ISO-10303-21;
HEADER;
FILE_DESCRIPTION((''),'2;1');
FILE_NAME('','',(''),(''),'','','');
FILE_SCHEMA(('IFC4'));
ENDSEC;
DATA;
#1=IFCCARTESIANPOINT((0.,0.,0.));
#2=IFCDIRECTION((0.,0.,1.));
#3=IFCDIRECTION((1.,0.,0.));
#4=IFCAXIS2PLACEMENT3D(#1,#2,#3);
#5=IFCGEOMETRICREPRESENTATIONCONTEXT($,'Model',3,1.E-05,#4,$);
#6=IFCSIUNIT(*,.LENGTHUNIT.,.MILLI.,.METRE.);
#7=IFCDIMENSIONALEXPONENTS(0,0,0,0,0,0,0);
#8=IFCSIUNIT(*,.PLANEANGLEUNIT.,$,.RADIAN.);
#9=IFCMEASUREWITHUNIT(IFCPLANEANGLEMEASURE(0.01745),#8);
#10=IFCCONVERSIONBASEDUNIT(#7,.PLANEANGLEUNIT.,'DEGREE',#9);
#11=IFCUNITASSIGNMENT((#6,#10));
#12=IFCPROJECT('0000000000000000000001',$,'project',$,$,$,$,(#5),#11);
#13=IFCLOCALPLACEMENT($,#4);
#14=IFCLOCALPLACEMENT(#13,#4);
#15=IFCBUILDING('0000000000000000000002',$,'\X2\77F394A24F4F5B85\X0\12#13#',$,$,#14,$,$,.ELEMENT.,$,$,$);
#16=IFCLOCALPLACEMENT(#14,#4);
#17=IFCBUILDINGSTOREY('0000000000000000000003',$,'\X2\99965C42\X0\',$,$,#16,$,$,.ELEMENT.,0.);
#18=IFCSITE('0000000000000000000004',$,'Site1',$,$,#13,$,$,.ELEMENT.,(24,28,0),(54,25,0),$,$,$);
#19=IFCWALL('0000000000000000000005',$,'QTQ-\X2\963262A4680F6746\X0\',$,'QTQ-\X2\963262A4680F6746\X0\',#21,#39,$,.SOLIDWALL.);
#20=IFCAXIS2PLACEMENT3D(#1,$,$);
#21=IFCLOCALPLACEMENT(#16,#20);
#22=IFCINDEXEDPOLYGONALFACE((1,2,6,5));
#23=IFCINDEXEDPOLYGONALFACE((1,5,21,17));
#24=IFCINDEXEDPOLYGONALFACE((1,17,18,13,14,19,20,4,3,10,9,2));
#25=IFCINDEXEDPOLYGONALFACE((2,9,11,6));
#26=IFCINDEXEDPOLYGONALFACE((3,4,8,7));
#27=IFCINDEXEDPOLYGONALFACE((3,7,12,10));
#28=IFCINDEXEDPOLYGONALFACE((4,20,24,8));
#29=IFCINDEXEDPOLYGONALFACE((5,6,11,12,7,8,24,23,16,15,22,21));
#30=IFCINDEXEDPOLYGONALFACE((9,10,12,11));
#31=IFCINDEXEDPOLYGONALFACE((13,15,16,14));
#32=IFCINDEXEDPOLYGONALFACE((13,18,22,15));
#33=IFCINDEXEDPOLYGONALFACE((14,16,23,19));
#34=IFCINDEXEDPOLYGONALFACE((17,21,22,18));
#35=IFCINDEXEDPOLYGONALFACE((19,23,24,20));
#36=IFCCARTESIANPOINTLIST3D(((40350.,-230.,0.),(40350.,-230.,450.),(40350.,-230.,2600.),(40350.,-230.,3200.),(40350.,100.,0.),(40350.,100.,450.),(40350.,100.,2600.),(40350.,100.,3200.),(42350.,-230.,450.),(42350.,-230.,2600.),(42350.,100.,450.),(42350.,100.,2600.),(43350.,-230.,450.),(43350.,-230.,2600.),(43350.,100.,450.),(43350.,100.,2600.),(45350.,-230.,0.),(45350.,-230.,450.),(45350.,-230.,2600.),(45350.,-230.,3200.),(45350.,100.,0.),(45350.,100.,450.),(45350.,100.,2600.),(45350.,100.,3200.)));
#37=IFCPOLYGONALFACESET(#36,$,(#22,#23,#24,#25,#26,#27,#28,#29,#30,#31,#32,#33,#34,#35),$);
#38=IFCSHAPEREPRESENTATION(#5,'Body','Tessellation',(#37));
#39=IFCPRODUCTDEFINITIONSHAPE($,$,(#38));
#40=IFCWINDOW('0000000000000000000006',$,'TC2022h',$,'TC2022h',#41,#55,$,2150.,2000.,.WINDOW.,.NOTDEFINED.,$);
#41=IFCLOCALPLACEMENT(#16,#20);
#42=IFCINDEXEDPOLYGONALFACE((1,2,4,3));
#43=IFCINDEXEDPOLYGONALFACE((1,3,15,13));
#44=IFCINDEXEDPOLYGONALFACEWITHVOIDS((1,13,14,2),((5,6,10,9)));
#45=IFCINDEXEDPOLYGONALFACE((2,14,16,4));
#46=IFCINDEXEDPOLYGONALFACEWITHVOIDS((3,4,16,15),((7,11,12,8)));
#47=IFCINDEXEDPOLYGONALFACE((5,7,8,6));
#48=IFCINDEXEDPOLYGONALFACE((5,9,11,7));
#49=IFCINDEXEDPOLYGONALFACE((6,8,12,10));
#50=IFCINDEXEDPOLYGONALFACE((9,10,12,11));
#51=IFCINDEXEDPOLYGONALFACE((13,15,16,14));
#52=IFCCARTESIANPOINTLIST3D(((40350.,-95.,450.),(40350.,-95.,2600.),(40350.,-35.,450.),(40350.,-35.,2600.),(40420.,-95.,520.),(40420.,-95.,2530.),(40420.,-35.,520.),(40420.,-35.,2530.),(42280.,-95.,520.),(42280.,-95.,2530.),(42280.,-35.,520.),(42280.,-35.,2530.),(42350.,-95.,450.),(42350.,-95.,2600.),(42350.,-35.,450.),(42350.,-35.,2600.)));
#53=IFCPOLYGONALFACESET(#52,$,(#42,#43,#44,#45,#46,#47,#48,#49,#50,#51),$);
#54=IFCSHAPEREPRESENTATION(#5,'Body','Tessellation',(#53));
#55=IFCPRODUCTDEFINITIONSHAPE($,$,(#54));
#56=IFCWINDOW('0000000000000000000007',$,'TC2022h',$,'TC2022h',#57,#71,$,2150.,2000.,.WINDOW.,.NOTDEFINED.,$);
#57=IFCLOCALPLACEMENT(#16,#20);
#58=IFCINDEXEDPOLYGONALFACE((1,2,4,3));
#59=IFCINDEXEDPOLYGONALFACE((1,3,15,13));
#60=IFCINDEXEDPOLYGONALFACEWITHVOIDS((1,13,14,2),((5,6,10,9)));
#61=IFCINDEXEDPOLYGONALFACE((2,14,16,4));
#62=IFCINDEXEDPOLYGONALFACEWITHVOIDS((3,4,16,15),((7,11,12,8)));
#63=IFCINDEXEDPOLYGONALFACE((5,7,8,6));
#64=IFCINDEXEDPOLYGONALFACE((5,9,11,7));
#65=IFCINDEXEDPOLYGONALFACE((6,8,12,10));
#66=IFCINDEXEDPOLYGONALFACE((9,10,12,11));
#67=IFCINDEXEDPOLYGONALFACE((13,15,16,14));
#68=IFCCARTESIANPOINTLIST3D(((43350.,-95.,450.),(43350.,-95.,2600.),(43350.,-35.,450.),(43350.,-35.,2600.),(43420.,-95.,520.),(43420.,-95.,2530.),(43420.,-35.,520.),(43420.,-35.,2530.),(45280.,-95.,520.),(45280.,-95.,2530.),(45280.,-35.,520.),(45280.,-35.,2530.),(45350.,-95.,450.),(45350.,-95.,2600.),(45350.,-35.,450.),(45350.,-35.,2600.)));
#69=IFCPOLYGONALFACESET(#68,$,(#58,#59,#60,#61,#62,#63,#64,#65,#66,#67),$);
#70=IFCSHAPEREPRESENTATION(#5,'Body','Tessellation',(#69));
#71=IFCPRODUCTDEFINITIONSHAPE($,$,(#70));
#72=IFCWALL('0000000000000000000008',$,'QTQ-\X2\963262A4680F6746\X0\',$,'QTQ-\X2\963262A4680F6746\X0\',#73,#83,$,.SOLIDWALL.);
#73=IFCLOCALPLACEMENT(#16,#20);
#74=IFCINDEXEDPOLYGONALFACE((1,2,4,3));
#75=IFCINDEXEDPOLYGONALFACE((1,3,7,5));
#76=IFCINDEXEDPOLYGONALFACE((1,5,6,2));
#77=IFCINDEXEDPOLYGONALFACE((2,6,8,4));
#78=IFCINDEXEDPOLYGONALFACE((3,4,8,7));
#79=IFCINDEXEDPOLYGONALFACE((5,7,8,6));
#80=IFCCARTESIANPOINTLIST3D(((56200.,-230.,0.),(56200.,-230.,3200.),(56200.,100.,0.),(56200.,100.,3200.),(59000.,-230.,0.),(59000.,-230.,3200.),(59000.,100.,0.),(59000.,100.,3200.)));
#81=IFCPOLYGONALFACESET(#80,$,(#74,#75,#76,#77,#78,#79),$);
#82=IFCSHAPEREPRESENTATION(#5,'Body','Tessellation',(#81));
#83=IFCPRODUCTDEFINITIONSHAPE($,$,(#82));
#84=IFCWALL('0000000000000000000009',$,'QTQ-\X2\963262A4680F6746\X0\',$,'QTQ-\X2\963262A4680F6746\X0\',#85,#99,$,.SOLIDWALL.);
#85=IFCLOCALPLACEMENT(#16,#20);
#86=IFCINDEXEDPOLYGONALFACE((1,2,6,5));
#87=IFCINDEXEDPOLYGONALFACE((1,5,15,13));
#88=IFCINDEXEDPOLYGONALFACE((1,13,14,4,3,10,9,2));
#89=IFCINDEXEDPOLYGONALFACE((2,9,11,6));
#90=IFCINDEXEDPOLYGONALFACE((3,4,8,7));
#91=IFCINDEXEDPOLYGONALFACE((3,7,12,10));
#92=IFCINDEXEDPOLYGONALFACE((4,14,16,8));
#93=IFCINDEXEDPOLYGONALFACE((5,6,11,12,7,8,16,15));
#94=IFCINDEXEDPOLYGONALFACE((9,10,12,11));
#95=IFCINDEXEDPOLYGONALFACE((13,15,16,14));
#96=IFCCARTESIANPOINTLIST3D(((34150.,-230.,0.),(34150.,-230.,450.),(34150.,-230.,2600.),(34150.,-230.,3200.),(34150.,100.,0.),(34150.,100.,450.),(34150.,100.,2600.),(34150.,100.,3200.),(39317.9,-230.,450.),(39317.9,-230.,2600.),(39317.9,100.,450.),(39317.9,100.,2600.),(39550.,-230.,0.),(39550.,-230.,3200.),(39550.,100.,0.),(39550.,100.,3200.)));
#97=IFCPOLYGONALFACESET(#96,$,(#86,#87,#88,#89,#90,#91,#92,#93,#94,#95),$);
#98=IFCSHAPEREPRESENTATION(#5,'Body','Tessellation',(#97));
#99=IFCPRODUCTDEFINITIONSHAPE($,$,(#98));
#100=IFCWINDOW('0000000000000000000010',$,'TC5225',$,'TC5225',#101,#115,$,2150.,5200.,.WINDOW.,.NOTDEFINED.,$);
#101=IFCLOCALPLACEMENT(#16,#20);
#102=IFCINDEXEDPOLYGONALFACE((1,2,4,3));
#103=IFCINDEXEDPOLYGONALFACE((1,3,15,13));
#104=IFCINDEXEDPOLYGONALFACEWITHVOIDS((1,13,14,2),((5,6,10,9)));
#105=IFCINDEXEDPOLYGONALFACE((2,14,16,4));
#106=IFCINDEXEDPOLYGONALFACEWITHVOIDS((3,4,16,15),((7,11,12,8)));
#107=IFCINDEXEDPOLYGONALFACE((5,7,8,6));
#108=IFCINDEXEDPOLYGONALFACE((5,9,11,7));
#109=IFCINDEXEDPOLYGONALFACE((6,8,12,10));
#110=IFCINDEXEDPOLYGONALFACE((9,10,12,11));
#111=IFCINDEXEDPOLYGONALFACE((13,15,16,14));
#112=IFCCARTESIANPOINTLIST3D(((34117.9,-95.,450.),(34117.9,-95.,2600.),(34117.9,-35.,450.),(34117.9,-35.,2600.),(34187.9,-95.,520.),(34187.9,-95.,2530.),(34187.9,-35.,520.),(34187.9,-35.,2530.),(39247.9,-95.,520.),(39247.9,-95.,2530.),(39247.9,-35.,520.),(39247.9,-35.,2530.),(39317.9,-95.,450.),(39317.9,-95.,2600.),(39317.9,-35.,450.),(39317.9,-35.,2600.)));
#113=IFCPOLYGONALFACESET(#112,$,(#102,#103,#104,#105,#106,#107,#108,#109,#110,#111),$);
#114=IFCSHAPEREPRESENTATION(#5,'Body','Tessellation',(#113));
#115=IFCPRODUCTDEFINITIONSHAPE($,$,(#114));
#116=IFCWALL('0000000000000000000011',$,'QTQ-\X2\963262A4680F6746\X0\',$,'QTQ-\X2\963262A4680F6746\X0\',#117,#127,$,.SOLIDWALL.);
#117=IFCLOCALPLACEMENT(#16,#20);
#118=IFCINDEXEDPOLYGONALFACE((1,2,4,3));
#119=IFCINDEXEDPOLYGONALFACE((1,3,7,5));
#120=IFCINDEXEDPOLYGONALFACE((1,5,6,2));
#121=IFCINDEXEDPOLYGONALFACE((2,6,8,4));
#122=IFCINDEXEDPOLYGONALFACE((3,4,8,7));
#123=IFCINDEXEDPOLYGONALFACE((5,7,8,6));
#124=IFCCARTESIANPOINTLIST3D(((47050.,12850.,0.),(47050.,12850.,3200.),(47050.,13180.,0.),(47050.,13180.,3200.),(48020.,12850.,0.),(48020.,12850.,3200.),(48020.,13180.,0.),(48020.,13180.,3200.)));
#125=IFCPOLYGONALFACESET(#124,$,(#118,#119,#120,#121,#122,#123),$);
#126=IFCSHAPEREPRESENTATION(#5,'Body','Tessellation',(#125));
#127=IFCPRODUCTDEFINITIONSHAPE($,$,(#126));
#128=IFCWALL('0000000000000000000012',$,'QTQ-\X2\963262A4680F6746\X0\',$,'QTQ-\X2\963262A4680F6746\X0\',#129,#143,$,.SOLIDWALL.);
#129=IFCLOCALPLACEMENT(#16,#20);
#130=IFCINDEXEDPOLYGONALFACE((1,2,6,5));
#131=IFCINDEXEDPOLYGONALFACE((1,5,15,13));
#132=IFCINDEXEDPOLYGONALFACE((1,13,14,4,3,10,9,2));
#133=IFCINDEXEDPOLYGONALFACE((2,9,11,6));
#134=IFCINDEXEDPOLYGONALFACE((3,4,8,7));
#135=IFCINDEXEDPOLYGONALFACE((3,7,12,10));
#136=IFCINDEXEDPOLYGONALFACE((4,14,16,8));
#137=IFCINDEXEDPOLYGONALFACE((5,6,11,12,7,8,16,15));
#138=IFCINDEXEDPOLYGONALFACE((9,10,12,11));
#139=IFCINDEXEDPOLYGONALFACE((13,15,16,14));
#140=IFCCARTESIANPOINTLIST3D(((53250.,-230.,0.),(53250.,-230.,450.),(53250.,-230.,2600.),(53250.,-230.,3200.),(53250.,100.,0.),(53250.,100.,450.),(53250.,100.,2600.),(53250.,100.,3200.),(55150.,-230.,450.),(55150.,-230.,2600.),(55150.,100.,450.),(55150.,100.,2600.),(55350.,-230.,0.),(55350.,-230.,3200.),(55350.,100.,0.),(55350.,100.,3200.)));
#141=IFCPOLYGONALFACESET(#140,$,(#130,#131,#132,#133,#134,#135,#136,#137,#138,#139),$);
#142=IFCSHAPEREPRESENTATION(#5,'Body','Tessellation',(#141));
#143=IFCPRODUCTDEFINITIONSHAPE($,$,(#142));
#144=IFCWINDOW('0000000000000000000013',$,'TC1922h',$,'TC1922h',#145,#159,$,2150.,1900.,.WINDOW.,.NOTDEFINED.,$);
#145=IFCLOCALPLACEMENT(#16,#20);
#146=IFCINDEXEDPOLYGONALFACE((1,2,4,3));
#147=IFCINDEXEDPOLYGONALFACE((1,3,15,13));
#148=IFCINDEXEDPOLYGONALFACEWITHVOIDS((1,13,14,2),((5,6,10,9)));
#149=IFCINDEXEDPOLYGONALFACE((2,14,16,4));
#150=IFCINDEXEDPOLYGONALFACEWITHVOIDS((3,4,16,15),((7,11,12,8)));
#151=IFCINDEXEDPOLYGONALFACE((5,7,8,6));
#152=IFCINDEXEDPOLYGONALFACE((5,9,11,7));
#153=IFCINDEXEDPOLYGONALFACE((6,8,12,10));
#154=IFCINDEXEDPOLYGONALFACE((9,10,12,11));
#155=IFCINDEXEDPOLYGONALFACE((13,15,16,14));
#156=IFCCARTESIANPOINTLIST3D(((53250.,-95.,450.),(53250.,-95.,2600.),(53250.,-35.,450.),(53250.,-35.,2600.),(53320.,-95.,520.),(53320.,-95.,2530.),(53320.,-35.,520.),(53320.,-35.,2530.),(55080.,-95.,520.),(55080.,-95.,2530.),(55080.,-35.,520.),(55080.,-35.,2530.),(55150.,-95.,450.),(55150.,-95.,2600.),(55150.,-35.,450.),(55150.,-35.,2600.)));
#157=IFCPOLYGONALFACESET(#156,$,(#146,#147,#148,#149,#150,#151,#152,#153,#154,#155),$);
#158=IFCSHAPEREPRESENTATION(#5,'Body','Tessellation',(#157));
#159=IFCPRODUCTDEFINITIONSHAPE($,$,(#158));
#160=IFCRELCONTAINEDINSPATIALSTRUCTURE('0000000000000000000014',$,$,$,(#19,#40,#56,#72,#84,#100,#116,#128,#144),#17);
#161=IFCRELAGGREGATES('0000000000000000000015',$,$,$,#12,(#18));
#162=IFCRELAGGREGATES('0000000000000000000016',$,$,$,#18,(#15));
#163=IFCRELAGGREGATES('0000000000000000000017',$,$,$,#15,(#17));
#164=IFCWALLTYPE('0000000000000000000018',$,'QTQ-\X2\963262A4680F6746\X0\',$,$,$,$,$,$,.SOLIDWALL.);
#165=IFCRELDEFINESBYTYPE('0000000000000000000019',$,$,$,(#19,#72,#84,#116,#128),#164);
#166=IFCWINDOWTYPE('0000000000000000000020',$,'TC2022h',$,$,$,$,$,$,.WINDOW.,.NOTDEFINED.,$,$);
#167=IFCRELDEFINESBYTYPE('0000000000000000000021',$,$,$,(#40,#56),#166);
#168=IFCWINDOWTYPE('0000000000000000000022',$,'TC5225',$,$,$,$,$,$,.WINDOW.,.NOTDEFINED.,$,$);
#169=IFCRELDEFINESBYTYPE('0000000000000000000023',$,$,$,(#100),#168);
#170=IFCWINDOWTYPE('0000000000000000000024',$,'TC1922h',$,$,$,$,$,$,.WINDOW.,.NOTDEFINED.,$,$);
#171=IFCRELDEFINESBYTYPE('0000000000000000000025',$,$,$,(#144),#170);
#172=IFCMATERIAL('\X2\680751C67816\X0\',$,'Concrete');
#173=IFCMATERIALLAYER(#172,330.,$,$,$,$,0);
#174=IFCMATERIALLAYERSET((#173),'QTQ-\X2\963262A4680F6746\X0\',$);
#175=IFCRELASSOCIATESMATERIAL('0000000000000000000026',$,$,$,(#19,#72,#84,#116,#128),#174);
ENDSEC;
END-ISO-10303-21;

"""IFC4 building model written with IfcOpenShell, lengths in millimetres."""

from ifc_helpers import new_model, entity, si_unit, converted_unit, frame, origin_with_axes, place, context, project, spatial, polyline, outline, extrude, material, layer, layer_set, type_object, element, fill, save


model = new_model("IFC4")

# Units and contexts
model_context = context("Model", 3, precision=1e-05, world=origin_with_axes())
ifc_project = project(units=[si_unit("LENGTHUNIT", "METRE", prefix="MILLI"), converted_unit("PLANEANGLEUNIT", "DEGREE", entity("IfcPlaneAngleMeasure", 0.01745), si_unit("PLANEANGLEUNIT", "RADIAN"), dimensions=[0, 0, 0, 0, 0, 0, 0])], contexts=[model_context])

# Site, building, storey
site_placement = place(None, origin_with_axes())
site = spatial("IfcSite", under=ifc_project, at=site_placement, Name="Site1", CompositionType="ELEMENT", RefLatitude=(24, 28, 0), RefLongitude=(54, 25, 0))
building_placement = place(site_placement, origin_with_axes())
building = spatial("IfcBuilding", under=site, at=building_placement, Name="石钢住宅12#13#", CompositionType="ELEMENT")
storey_placement = place(building_placement, origin_with_axes())
storey = spatial("IfcBuildingStorey", under=building, at=storey_placement, Name="首层", CompositionType="ELEMENT", Elevation=0.0)

# Shared definitions
ifc_material_1 = material(Name="标准砖", Category="Concrete")
ifc_layer_1 = layer(ifc_material_1, 330.0, Priority=0)
ifc_layer_set_1 = layer_set([ifc_layer_1], Name="QTQ-防护栏杆")
wall_type_1 = type_object("IfcWallType", Name="QTQ-防护栏杆", PredefinedType="SOLIDWALL")

# Wall, openings, windows
wall_1_placement = place(storey_placement, origin_with_axes())
wall_1 = element("IfcWall", 1, at=wall_1_placement, inside=storey, type_object=wall_type_1, material=ifc_layer_set_1, Name="QTQ-防护栏杆", ObjectType="QTQ-防护栏杆", PredefinedType="SOLIDWALL", context=model_context, shape_type="SweptSolid", body=[
    extrude(outline(polyline([(0.0, 0.0), (3200.0, 0.0), (3200.0, 5000.0), (0.0, 5000.0), (0.0, 0.0)])), frame((45350.0, -230.0, 3200.0), z_axis=(0.0, 1.0, 0.0), x_axis=(0.0, 0.0, -1.0)), (0.0, 0.0, 1.0), 330.0),
])
opening_1_placement = place(storey_placement, origin_with_axes())
opening_1 = element("IfcOpeningElement", 2, at=opening_1_placement, cuts=wall_1, PredefinedType="OPENING", context=model_context, shape_type="SweptSolid", body=[
    extrude(outline(polyline([(0.0, 0.0), (2000.0, 0.0), (2000.0, 2150.0), (0.0, 2150.0), (0.0, 0.0)])), frame((42350.0, -1230.0, 450.0), z_axis=(0.0, 1.0, 0.0), x_axis=(-1.0, 0.0, 0.0)), (0.0, 0.0, 1.0), 2330.0),
])
opening_2_placement = place(storey_placement, origin_with_axes())
opening_2 = element("IfcOpeningElement", 3, at=opening_2_placement, cuts=wall_1, PredefinedType="OPENING", context=model_context, shape_type="SweptSolid", body=[
    extrude(outline(polyline([(0.0, 0.0), (2000.0, 0.0), (2000.0, 2150.0), (0.0, 2150.0), (0.0, 0.0)])), frame((45350.0, -1230.0, 450.0), z_axis=(0.0, 1.0, 0.0), x_axis=(-1.0, 0.0, 0.0)), (0.0, 0.0, 1.0), 2330.0),
])
window_type_1 = type_object("IfcWindowType", Name="TC2022h", PartitioningType="NOTDEFINED", PredefinedType="WINDOW")
window_1_placement = place(storey_placement, origin_with_axes())
window_1 = element("IfcWindow", 4, at=window_1_placement, inside=storey, type_object=window_type_1, Name="TC2022h", ObjectType="TC2022h", OverallHeight=2150.0, OverallWidth=2000.0, PartitioningType="NOTDEFINED", PredefinedType="WINDOW", context=model_context, shape_type="SweptSolid", body=[
    extrude(outline(polyline([(-1000.0, -1075.0), (1000.0, -1075.0), (1000.0, 1075.0), (-1000.0, 1075.0), (-1000.0, -1075.0)]), holes=[polyline([(-930.0, -1005.0), (-930.0, 1005.0), (930.0, 1005.0), (930.0, -1005.0), (-930.0, -1005.0)])]), frame((41350.0, -95.0, 1525.0), z_axis=(0.0, 1.0, 0.0), x_axis=(-1.0, 0.0, 0.0)), (0.0, 0.0, 1.0), 60.0),
])
fill(opening_1, window_1)
window_2_placement = place(storey_placement, origin_with_axes())
window_2 = element("IfcWindow", 5, at=window_2_placement, inside=storey, type_object=window_type_1, Name="TC2022h", ObjectType="TC2022h", OverallHeight=2150.0, OverallWidth=2000.0, PartitioningType="NOTDEFINED", PredefinedType="WINDOW", context=model_context, shape_type="SweptSolid", body=[
    extrude(outline(polyline([(-1000.0, -1075.0), (1000.0, -1075.0), (1000.0, 1075.0), (-1000.0, 1075.0), (-1000.0, -1075.0)]), holes=[polyline([(-930.0, -1005.0), (-930.0, 1005.0), (930.0, 1005.0), (930.0, -1005.0), (-930.0, -1005.0)])]), frame((44350.0, -95.0, 1525.0), z_axis=(0.0, 1.0, 0.0), x_axis=(-1.0, 0.0, 0.0)), (0.0, 0.0, 1.0), 60.0),
])
fill(opening_2, window_2)

# Wall
wall_2_placement = place(storey_placement, origin_with_axes())
element("IfcWall", 6, at=wall_2_placement, inside=storey, type_object=wall_type_1, material=ifc_layer_set_1, Name="QTQ-防护栏杆", ObjectType="QTQ-防护栏杆", PredefinedType="SOLIDWALL", context=model_context, shape_type="SweptSolid", body=[
    extrude(outline(polyline([(0.0, 0.0), (3200.0, 0.0), (3200.0, 2800.0), (0.0, 2800.0), (0.0, 0.0)])), frame((59000.0, -230.0, 3200.0), z_axis=(0.0, 1.0, 0.0), x_axis=(0.0, 0.0, -1.0)), (0.0, 0.0, 1.0), 330.0),
])

# Wall, opening, window
wall_3_placement = place(storey_placement, origin_with_axes())
wall_3 = element("IfcWall", 7, at=wall_3_placement, inside=storey, type_object=wall_type_1, material=ifc_layer_set_1, Name="QTQ-防护栏杆", ObjectType="QTQ-防护栏杆", PredefinedType="SOLIDWALL", context=model_context, shape_type="SweptSolid", body=[
    extrude(outline(polyline([(0.0, 0.0), (3200.0, 0.0), (3200.0, 5400.0), (0.0, 5400.0), (0.0, 0.0)])), frame((39550.0, -230.0, 3200.0), z_axis=(0.0, 1.0, 0.0), x_axis=(0.0, 0.0, -1.0)), (0.0, 0.0, 1.0), 330.0),
])
opening_3_placement = place(storey_placement, origin_with_axes())
opening_3 = element("IfcOpeningElement", 8, at=opening_3_placement, cuts=wall_3, PredefinedType="OPENING", context=model_context, shape_type="SweptSolid", body=[
    extrude(outline(polyline([(0.0, 0.0), (5200.0, 0.0), (5200.0, 2150.0), (0.0, 2150.0), (0.0, 0.0)])), frame((39317.9, -1230.0, 450.0), z_axis=(0.0, 1.0, 0.0), x_axis=(-1.0, 0.0, 0.0)), (0.0, 0.0, 1.0), 2330.0),
])
window_type_2 = type_object("IfcWindowType", Name="TC5225", PartitioningType="NOTDEFINED", PredefinedType="WINDOW")
window_3_placement = place(storey_placement, origin_with_axes())
window_3 = element("IfcWindow", 9, at=window_3_placement, inside=storey, type_object=window_type_2, Name="TC5225", ObjectType="TC5225", OverallHeight=2150.0, OverallWidth=5200.0, PartitioningType="NOTDEFINED", PredefinedType="WINDOW", context=model_context, shape_type="SweptSolid", body=[
    extrude(outline(polyline([(-2600.0, -1075.0), (2600.0, -1075.0), (2600.0, 1075.0), (-2600.0, 1075.0), (-2600.0, -1075.0)]), holes=[polyline([(-2530.0, -1005.0), (-2530.0, 1005.0), (2530.0, 1005.0), (2530.0, -1005.0), (-2530.0, -1005.0)])]), frame((36717.9, -95.0, 1525.0), z_axis=(0.0, 1.0, 0.0), x_axis=(-1.0, 0.0, 0.0)), (0.0, 0.0, 1.0), 60.0),
])
fill(opening_3, window_3)

# Wall
wall_4_placement = place(storey_placement, origin_with_axes())
element("IfcWall", 10, at=wall_4_placement, inside=storey, type_object=wall_type_1, material=ifc_layer_set_1, Name="QTQ-防护栏杆", ObjectType="QTQ-防护栏杆", PredefinedType="SOLIDWALL", context=model_context, shape_type="SweptSolid", body=[
    extrude(outline(polyline([(0.0, 0.0), (3200.0, 0.0), (3200.0, 970.0), (0.0, 970.0), (0.0, 0.0)])), frame((47050.0, 13180.0, 3200.0), z_axis=(0.0, -1.0, 0.0), x_axis=(0.0, 0.0, -1.0)), (0.0, 0.0, 1.0), 330.0),
])

# Wall, opening, window
wall_5_placement = place(storey_placement, origin_with_axes())
wall_5 = element("IfcWall", 11, at=wall_5_placement, inside=storey, type_object=wall_type_1, material=ifc_layer_set_1, Name="QTQ-防护栏杆", ObjectType="QTQ-防护栏杆", PredefinedType="SOLIDWALL", context=model_context, shape_type="SweptSolid", body=[
    extrude(outline(polyline([(0.0, 0.0), (3200.0, 0.0), (3200.0, 2100.0), (0.0, 2100.0), (0.0, 0.0)])), frame((55350.0, -230.0, 3200.0), z_axis=(0.0, 1.0, 0.0), x_axis=(0.0, 0.0, -1.0)), (0.0, 0.0, 1.0), 330.0),
])
opening_4_placement = place(storey_placement, origin_with_axes())
opening_4 = element("IfcOpeningElement", 12, at=opening_4_placement, cuts=wall_5, PredefinedType="OPENING", context=model_context, shape_type="SweptSolid", body=[
    extrude(outline(polyline([(0.0, 0.0), (1900.0, 0.0), (1900.0, 2150.0), (0.0, 2150.0), (0.0, 0.0)])), frame((55150.0, -1230.0, 450.0), z_axis=(0.0, 1.0, 0.0), x_axis=(-1.0, 0.0, 0.0)), (0.0, 0.0, 1.0), 2330.0),
])
window_type_3 = type_object("IfcWindowType", Name="TC1922h", PartitioningType="NOTDEFINED", PredefinedType="WINDOW")
window_4_placement = place(storey_placement, origin_with_axes())
window_4 = element("IfcWindow", 13, at=window_4_placement, inside=storey, type_object=window_type_3, Name="TC1922h", ObjectType="TC1922h", OverallHeight=2150.0, OverallWidth=1900.0, PartitioningType="NOTDEFINED", PredefinedType="WINDOW", context=model_context, shape_type="SweptSolid", body=[
    extrude(outline(polyline([(-950.0, -1075.0), (950.0, -1075.0), (950.0, 1075.0), (-950.0, 1075.0), (-950.0, -1075.0)]), holes=[polyline([(-880.0, -1005.0), (-880.0, 1005.0), (880.0, 1005.0), (880.0, -1005.0), (-880.0, -1005.0)])]), frame((54200.0, -95.0, 1525.0), z_axis=(0.0, 1.0, 0.0), x_axis=(-1.0, 0.0, 0.0)), (0.0, 0.0, 1.0), 60.0),
])
fill(opening_4, window_4)

save(model, "model.ifc")
